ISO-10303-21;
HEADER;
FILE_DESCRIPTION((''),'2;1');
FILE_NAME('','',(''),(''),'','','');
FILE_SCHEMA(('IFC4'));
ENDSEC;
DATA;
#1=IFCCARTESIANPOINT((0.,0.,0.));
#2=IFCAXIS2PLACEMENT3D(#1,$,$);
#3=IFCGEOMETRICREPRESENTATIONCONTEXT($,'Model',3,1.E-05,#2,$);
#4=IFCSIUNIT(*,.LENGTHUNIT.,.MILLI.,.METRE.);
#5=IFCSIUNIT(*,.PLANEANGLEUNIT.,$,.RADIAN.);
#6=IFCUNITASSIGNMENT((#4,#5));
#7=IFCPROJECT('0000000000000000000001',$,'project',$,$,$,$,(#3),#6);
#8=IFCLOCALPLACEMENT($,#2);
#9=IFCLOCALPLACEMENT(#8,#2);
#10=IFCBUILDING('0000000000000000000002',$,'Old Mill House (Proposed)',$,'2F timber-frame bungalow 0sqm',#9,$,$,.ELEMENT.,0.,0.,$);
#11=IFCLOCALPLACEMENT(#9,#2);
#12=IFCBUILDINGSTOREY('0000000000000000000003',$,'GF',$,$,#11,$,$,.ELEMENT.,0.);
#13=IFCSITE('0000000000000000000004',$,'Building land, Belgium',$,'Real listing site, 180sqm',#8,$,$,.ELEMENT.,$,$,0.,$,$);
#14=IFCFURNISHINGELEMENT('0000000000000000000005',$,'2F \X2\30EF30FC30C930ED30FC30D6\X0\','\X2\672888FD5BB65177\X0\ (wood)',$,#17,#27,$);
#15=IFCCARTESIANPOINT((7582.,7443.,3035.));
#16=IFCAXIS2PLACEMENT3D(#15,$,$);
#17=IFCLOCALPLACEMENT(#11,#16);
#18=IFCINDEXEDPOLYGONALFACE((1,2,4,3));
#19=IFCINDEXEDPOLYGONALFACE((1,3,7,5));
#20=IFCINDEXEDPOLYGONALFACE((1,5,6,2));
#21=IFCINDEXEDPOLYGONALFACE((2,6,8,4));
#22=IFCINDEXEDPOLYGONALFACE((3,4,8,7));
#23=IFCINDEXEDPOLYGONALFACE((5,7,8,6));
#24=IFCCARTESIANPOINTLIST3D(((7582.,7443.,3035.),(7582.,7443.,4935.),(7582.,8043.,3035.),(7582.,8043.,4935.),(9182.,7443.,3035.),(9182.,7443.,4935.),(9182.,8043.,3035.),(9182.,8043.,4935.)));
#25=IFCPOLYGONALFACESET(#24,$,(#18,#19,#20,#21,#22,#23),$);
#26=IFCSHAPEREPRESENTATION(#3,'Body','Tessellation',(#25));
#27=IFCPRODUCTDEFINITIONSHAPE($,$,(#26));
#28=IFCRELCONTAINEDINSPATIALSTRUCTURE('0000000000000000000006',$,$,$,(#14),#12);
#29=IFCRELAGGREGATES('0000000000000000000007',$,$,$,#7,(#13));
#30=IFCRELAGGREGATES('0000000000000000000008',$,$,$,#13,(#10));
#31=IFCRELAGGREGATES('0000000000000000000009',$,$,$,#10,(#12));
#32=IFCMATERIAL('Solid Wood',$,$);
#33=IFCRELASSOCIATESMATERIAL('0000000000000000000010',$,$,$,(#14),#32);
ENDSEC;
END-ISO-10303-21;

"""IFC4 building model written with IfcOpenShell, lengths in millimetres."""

from ifc_helpers import new_model, si_unit, frame, frame_2d, origin, place, context, project, spatial, rectangle, extrude, material, element, save


model = new_model("IFC4")

# Units and contexts
model_context = context("Model", 3, precision=1e-05, world=origin())
ifc_project = project(units=[si_unit("LENGTHUNIT", "METRE", prefix="MILLI"), si_unit("PLANEANGLEUNIT", "RADIAN")], contexts=[model_context])

# Site, building, storey
site_placement = place(None, origin())
site = spatial("IfcSite", under=ifc_project, at=site_placement, Name="Building land, Belgium", ObjectType="Real listing site, 180sqm", CompositionType="ELEMENT", RefElevation=0.0)
building_placement = place(site_placement, origin())
building = spatial("IfcBuilding", under=site, at=building_placement, Name="Old Mill House (Proposed)", ObjectType="2F timber-frame bungalow 0sqm", CompositionType="ELEMENT", ElevationOfRefHeight=0.0, ElevationOfTerrain=0.0)
storey_placement = place(building_placement, origin())
storey = spatial("IfcBuildingStorey", under=building, at=storey_placement, Name="GF", CompositionType="ELEMENT", Elevation=0.0)

# Shared definitions
ifc_material_1 = material(Name="Solid Wood")

# Furnishing element
furnishing_1_placement = place(storey_placement, frame((7582.0, 7443.0, 3035.0)))
element("IfcFurnishingElement", 1, at=furnishing_1_placement, inside=storey, material=ifc_material_1, Name="2F ワードローブ", Description="木製家具 (wood)", context=model_context, shape_type="SweptSolid", body=[
    extrude(rectangle(XDim=1600.0, YDim=600.0, at=frame_2d((800.0, 300.0))), frame((7582.0, 7443.0, 3035.0)), (0.0, 0.0, 1.0), 1900.0),
])

save(model, "model.ifc")
